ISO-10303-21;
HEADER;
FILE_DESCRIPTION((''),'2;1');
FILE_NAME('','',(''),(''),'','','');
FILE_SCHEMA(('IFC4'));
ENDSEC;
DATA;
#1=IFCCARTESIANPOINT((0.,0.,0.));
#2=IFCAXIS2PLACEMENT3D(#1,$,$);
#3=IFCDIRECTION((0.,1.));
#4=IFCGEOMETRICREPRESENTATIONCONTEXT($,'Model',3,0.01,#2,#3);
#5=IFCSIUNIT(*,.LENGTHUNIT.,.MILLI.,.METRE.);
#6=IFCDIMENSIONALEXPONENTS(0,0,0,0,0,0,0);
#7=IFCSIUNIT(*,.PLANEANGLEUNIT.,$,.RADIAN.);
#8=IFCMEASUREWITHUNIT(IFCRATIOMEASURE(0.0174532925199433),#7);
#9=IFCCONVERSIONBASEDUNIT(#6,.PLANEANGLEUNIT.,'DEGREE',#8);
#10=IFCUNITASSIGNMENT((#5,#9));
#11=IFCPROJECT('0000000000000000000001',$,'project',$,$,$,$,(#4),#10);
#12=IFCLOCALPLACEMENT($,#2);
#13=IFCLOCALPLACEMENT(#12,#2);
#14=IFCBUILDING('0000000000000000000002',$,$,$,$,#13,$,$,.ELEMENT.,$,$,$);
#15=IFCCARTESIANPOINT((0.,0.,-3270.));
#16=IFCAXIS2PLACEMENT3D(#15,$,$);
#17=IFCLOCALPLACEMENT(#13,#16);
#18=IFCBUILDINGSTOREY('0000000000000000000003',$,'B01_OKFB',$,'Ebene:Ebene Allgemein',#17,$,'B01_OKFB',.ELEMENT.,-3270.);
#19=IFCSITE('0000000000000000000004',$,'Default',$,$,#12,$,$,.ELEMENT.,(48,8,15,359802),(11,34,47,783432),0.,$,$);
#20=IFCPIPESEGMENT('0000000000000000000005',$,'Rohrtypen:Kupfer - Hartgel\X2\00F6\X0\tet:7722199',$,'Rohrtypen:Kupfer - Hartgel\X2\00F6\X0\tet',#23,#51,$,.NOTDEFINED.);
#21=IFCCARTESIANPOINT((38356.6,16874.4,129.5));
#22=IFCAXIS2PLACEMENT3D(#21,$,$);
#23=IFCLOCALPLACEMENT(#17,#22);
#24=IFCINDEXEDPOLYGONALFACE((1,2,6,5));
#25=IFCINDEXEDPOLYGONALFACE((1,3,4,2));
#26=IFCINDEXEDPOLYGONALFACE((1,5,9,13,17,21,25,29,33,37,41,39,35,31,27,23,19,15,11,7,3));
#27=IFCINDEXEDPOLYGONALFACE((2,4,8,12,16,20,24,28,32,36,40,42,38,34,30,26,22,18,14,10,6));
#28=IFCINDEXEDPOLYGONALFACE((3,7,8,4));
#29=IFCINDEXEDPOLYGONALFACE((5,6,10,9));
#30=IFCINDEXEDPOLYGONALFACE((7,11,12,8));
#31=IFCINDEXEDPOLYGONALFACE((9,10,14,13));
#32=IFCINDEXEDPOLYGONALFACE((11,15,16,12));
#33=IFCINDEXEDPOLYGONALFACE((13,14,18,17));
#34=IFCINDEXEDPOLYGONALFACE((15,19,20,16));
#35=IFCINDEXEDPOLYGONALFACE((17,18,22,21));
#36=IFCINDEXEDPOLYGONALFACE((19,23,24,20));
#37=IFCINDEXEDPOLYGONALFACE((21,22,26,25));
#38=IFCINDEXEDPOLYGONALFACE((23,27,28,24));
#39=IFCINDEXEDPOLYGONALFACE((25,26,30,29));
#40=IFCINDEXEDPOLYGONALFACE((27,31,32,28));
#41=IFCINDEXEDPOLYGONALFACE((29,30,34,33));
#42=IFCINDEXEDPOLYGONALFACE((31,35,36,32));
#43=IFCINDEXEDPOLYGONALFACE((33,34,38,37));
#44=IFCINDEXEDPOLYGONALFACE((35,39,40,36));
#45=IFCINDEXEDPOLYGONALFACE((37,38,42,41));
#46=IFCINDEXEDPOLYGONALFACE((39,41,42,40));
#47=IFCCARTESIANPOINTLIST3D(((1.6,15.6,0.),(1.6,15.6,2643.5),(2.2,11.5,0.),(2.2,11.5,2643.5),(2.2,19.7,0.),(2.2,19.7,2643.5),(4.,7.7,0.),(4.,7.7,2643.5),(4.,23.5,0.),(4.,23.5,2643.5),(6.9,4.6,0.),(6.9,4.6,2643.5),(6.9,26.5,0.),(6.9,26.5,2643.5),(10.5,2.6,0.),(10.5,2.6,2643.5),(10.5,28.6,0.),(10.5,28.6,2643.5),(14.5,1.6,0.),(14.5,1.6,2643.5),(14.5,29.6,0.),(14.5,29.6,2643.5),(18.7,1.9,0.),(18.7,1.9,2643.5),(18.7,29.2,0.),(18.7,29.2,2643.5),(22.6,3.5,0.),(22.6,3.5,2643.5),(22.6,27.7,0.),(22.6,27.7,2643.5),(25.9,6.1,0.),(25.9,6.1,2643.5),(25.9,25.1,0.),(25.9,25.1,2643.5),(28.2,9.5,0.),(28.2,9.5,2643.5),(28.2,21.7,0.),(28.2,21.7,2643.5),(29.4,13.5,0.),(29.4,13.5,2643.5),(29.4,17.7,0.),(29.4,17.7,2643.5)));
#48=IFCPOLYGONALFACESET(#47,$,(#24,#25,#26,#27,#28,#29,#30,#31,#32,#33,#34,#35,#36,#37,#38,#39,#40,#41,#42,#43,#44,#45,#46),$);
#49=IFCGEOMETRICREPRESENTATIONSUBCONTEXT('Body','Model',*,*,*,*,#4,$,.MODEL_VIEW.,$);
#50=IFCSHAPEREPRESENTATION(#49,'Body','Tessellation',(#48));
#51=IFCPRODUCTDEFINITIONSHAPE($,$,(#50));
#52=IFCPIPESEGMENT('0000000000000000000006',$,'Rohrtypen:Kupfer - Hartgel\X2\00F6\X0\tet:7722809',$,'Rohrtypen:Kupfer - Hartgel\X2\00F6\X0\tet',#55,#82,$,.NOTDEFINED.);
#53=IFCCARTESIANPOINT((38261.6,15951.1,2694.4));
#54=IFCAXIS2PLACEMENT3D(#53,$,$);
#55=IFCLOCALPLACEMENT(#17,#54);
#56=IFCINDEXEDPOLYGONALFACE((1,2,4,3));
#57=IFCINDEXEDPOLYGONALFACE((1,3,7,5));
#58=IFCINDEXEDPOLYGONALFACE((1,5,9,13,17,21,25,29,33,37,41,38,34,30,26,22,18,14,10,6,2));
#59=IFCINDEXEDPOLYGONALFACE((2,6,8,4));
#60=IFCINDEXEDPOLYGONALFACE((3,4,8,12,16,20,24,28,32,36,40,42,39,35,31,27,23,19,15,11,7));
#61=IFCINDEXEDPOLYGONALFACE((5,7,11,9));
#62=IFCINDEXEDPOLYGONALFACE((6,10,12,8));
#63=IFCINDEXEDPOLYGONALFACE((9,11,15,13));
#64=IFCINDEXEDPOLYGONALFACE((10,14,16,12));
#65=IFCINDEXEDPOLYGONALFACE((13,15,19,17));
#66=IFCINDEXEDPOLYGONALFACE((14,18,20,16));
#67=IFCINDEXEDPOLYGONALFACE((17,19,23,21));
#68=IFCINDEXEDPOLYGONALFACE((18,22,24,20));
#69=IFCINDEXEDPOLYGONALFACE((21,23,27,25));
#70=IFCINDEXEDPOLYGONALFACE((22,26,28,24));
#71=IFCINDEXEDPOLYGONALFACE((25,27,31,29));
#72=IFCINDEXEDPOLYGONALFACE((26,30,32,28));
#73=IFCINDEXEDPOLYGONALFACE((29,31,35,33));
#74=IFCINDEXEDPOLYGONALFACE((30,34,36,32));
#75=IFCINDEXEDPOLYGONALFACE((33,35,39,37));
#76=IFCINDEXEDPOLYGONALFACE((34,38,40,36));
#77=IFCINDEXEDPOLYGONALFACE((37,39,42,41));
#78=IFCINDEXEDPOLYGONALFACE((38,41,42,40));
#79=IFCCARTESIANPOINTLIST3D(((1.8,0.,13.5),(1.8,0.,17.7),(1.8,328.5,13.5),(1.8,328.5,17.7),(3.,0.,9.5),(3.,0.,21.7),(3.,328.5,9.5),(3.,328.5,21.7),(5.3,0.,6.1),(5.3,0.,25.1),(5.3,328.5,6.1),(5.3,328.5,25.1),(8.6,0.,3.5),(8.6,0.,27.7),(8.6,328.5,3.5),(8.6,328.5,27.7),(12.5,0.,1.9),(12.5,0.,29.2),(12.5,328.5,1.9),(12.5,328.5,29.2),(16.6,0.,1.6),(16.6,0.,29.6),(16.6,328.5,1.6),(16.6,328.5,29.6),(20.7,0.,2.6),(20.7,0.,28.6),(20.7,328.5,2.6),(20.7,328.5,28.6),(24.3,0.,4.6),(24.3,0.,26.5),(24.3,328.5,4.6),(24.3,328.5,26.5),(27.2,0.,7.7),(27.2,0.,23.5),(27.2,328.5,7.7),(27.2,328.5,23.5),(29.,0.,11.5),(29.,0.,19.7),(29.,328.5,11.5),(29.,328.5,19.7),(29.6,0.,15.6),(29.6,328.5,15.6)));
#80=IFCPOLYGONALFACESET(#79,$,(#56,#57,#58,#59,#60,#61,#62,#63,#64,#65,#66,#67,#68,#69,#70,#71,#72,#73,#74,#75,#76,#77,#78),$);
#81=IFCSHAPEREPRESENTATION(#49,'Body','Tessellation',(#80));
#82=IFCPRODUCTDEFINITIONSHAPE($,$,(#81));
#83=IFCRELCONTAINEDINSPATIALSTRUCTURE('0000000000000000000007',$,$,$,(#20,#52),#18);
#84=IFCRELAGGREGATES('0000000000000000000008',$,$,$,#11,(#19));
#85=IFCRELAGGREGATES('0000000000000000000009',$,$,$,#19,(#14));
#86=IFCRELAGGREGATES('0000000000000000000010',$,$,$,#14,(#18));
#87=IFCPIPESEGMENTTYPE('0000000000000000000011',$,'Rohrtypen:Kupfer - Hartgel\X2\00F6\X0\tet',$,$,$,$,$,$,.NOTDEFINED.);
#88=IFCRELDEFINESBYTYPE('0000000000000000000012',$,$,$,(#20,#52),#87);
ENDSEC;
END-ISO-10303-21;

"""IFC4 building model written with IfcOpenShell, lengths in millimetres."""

from ifc_helpers import new_model, entity, si_unit, converted_unit, direction, frame, frame_2d, origin, origin_2d_with_axis, place, context, subcontext, project, spatial, circle, extrude, type_object, element, save


model = new_model("IFC4")

# Units and contexts
model_context = context("Model", 3, precision=0.01, world=origin(), true_north=direction((0.0, 1.0)))
body_context = subcontext(model_context, "Body", "Model", "MODEL_VIEW")
ifc_project = project(units=[si_unit("LENGTHUNIT", "METRE", prefix="MILLI"), converted_unit("PLANEANGLEUNIT", "DEGREE", entity("IfcRatioMeasure", 0.0174532925199433), si_unit("PLANEANGLEUNIT", "RADIAN"), dimensions=[0, 0, 0, 0, 0, 0, 0])], contexts=[model_context])

# Site, building, storey
site_placement = place(None, origin())
site = spatial("IfcSite", under=ifc_project, at=site_placement, Name="Default", CompositionType="ELEMENT", RefLatitude=(48, 8, 15, 359802), RefLongitude=(11, 34, 47, 783432), RefElevation=0.0)
building_placement = place(site_placement, origin())
building = spatial("IfcBuilding", under=site, at=building_placement, CompositionType="ELEMENT")
storey_placement = place(building_placement, frame((0.0, 0.0, -3270.0)))
storey = spatial("IfcBuildingStorey", under=building, at=storey_placement, Name="B01_OKFB", ObjectType="Ebene:Ebene Allgemein", LongName="B01_OKFB", CompositionType="ELEMENT", Elevation=-3270.0)

# Pipe segments
pipe_segment_type = type_object("IfcPipeSegmentType", Name="Rohrtypen:Kupfer - Hartgelötet", PredefinedType="NOTDEFINED")
pipe_segment_1_placement = place(storey_placement, frame((38356.6, 16874.4, 129.5)))
element("IfcPipeSegment", 1, at=pipe_segment_1_placement, inside=storey, type_object=pipe_segment_type, Name="Rohrtypen:Kupfer - Hartgelötet:7722199", ObjectType="Rohrtypen:Kupfer - Hartgelötet", PredefinedType="NOTDEFINED", context=body_context, shape_type="SweptSolid", body=[
    extrude(circle(Radius=14.0, at=frame_2d((0.0, 0.0), x_axis=(1.0, 0.0))), frame((15.6, 15.6, 0.0), z_axis=(0.0, 0.0, 1.0), x_axis=(-1.0, 0.0, 0.0)), (0.0, 0.0, 1.0), 2643.5),
])
pipe_segment_2_placement = place(storey_placement, frame((38261.6, 15951.1, 2694.4)))
element("IfcPipeSegment", 2, at=pipe_segment_2_placement, inside=storey, type_object=pipe_segment_type, Name="Rohrtypen:Kupfer - Hartgelötet:7722809", ObjectType="Rohrtypen:Kupfer - Hartgelötet", PredefinedType="NOTDEFINED", context=body_context, shape_type="SweptSolid", body=[
    extrude(circle(Radius=14.0, at=origin_2d_with_axis()), frame((15.6, 0.0, 15.6), z_axis=(0.0, 1.0, 0.0), x_axis=(1.0, 0.0, 0.0)), (0.0, 0.0, 1.0), 328.5),
])

save(model, "model.ifc")
